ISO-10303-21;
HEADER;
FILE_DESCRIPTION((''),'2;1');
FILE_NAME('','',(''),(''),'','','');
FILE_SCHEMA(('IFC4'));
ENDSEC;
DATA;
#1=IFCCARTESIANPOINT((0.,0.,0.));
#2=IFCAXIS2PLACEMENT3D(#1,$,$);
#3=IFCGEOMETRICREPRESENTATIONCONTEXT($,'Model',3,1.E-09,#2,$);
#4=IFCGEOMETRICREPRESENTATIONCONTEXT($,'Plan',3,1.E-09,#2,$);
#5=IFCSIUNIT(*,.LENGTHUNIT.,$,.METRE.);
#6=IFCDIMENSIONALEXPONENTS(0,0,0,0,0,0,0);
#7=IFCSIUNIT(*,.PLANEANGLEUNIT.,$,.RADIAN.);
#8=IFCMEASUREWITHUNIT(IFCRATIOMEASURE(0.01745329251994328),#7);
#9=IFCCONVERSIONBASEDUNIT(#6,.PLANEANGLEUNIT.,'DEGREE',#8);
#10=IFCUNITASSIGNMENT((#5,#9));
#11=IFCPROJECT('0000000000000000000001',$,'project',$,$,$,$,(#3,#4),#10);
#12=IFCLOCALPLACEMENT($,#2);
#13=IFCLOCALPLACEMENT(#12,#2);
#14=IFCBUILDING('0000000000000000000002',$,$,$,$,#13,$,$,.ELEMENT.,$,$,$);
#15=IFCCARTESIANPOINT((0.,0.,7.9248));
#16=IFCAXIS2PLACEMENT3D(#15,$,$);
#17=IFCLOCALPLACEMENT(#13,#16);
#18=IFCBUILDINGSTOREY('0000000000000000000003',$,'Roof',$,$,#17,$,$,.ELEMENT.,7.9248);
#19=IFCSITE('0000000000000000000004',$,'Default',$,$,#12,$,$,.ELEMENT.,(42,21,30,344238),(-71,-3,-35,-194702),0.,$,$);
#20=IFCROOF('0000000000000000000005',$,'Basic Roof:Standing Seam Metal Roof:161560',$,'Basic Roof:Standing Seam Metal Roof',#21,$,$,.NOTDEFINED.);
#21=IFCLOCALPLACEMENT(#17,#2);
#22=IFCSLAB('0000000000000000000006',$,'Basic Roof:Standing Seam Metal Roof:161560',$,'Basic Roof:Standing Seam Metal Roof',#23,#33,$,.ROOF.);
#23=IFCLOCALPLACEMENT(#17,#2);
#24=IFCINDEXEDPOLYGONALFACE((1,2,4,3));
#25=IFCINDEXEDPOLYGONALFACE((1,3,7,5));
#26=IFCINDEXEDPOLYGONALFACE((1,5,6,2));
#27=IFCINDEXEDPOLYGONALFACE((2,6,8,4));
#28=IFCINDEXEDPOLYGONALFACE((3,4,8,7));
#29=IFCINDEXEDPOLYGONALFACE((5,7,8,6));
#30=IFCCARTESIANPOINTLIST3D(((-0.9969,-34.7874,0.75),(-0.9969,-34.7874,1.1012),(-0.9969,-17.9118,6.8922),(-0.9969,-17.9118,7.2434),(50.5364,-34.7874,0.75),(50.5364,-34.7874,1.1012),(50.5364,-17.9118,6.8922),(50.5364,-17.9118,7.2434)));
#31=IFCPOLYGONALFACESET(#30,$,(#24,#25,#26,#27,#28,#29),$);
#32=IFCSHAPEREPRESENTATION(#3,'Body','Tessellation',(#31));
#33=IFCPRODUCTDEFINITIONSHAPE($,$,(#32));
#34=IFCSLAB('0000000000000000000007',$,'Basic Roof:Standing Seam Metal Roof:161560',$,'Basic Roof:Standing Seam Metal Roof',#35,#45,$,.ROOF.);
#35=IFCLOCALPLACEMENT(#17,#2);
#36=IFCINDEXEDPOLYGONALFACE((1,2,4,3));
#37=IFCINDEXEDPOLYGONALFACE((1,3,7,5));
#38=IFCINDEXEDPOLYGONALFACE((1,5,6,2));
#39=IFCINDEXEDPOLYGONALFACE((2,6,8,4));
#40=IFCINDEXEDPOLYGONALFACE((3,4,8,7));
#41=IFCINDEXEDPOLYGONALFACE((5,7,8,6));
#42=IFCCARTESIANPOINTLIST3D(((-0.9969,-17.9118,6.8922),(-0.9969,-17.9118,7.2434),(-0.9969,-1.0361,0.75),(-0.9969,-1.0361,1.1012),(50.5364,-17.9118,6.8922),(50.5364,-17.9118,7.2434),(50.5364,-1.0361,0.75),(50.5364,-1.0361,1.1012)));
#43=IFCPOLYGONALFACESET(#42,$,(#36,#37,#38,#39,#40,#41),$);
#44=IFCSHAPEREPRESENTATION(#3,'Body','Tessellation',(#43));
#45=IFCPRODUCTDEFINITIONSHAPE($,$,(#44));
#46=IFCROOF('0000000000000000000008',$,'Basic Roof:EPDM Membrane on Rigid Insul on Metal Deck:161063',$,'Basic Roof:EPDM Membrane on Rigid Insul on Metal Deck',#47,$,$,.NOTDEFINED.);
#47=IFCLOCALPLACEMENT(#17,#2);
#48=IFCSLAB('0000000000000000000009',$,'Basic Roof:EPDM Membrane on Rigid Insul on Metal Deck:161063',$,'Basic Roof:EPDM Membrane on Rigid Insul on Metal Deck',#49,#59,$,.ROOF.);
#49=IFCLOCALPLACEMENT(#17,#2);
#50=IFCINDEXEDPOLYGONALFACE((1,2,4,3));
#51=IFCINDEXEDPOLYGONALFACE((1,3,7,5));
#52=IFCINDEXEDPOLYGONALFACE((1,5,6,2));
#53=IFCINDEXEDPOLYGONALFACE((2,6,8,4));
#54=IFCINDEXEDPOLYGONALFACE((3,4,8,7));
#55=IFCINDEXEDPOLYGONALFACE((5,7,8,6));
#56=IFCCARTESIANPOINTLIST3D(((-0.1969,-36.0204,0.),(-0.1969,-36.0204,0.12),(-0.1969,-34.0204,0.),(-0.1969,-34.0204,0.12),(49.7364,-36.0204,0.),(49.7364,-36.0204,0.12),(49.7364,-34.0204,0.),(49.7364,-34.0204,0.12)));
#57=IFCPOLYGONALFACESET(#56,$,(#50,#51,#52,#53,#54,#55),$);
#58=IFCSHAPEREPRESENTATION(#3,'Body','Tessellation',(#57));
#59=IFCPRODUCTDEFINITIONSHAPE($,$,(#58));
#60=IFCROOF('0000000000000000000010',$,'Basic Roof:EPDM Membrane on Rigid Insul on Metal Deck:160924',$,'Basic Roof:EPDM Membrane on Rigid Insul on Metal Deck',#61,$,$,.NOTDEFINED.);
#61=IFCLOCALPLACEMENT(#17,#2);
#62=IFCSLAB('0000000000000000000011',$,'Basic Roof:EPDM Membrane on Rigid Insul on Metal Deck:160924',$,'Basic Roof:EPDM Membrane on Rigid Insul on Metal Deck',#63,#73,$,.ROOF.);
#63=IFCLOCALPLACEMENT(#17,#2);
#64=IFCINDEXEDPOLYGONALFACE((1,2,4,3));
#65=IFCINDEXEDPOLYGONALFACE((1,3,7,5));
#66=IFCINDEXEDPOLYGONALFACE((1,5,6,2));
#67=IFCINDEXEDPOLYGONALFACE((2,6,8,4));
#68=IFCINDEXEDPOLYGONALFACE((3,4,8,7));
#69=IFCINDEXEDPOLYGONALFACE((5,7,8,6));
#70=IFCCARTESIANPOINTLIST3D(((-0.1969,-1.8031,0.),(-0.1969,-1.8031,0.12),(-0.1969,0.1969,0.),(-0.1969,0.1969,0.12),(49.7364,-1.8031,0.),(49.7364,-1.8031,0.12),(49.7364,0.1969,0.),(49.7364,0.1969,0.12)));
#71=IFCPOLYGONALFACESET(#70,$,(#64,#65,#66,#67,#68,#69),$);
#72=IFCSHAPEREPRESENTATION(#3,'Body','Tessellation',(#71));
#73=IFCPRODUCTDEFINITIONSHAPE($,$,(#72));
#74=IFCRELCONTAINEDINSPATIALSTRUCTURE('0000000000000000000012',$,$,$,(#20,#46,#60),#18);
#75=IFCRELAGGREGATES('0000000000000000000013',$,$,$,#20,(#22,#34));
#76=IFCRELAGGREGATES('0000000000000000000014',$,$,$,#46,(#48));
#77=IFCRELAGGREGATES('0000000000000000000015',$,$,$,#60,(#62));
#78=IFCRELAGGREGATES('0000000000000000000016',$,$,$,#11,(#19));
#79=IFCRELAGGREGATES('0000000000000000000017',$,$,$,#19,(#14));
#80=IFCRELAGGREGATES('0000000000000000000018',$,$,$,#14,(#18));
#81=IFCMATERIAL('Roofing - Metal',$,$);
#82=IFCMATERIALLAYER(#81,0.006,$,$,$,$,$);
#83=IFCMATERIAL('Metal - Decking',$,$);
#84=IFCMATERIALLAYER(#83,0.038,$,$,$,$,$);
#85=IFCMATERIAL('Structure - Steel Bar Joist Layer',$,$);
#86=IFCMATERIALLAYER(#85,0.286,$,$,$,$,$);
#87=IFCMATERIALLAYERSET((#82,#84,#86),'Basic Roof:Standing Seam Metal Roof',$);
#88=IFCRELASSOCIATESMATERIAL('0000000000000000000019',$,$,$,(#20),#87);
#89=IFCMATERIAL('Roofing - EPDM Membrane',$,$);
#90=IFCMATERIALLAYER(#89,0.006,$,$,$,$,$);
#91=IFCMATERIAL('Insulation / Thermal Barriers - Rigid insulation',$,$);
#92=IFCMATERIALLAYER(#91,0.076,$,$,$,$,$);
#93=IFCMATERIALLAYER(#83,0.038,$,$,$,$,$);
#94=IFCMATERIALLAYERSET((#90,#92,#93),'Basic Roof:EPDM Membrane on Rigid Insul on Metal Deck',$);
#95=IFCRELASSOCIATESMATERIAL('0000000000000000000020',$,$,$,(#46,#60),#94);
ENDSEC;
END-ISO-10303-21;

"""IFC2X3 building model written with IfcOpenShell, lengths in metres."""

from ifc_helpers import new_model, entity, si_unit, converted_unit, frame, frame_2d, origin, origin_2d_with_axis, place, context, project, spatial, rectangle, extrude, material, layer, layer_set, layer_usage, element, aggregate, save


model = new_model("IFC2X3")

# Units and contexts
model_context = context("Model", 3, precision=1e-09, world=origin())
plan_context = context("Plan", 3, precision=1e-09, world=origin())
ifc_project = project(units=[si_unit("LENGTHUNIT", "METRE"), converted_unit("PLANEANGLEUNIT", "DEGREE", entity("IfcRatioMeasure", 0.01745329251994328), si_unit("PLANEANGLEUNIT", "RADIAN"), dimensions=[0, 0, 0, 0, 0, 0, 0])], contexts=[model_context, plan_context])

# Site, building, storey
site_placement = place(None, origin())
site = spatial("IfcSite", under=ifc_project, at=site_placement, Name="Default", CompositionType="ELEMENT", RefLatitude=(42, 21, 30, 344238), RefLongitude=(-71, -3, -35, -194702), RefElevation=0.0)
building_placement = place(site_placement, origin())
building = spatial("IfcBuilding", under=site, at=building_placement, CompositionType="ELEMENT")
storey_placement = place(building_placement, frame((0.0, 0.0, 7.9248)))
storey = spatial("IfcBuildingStorey", under=building, at=storey_placement, Name="Roof", CompositionType="ELEMENT", Elevation=7.9248)

# Roof, slabs
ifc_material_1 = material(Name="Roofing - Metal")
ifc_layer_1 = layer(ifc_material_1, 0.006)
ifc_material_2 = material(Name="Metal - Decking")
ifc_layer_2 = layer(ifc_material_2, 0.038)
ifc_material_3 = material(Name="Structure - Steel Bar Joist Layer")
ifc_layer_3 = layer(ifc_material_3, 0.286)
ifc_layer_set_1 = layer_set([ifc_layer_1, ifc_layer_2, ifc_layer_3], Name="Basic Roof:Standing Seam Metal Roof")
ifc_layer_usage_1 = layer_usage(ifc_layer_set_1, "AXIS3", "NEGATIVE", 0.0)
roof_1_placement = place(storey_placement, origin())
roof_1 = element("IfcRoof", 1, at=roof_1_placement, inside=storey, material=ifc_layer_usage_1, Name="Basic Roof:Standing Seam Metal Roof:161560", ObjectType="Basic Roof:Standing Seam Metal Roof", ShapeType="NOTDEFINED")
slab_1_placement = place(roof_1_placement, frame((-0.9969, -34.7874, 0.75)))
slab_1 = element("IfcSlab", 2, at=slab_1_placement, Name="Basic Roof:Standing Seam Metal Roof:161560", ObjectType="Basic Roof:Standing Seam Metal Roof", PredefinedType="ROOF", context=model_context, shape_type="SweptSolid", body=[
    extrude(rectangle(XDim=17.9587, YDim=51.5333, at=frame_2d((0.0, 0.0), x_axis=(0.0, 1.0))), frame((25.7667, 8.4378, 3.0711), z_axis=(0.0, -0.34202, 0.939693), x_axis=(1.0, 0.0, 0.0)), (0.0, 0.34202, 0.939693), 0.3512),
])
slab_2_placement = place(roof_1_placement, frame((-0.9969, -34.7874, 0.75)))
slab_2 = element("IfcSlab", 3, at=slab_2_placement, Name="Basic Roof:Standing Seam Metal Roof:161560", ObjectType="Basic Roof:Standing Seam Metal Roof", PredefinedType="ROOF", context=model_context, shape_type="SweptSolid", body=[
    extrude(rectangle(XDim=51.5333, YDim=17.9587, at=origin_2d_with_axis()), frame((25.7667, 25.3135, 3.0711), z_axis=(0.0, 0.34202, 0.939693), x_axis=(1.0, 0.0, 0.0)), (0.0, -0.34202, 0.939693), 0.3512),
])
aggregate(roof_1, [slab_1, slab_2])

# Roofs, slabs
ifc_material_4 = material(Name="Roofing - EPDM Membrane")
ifc_layer_4 = layer(ifc_material_4, 0.006)
ifc_material_5 = material(Name="Insulation / Thermal Barriers - Rigid insulation")
ifc_layer_5 = layer(ifc_material_5, 0.076)
ifc_layer_6 = layer(ifc_material_2, 0.038)
ifc_layer_set_2 = layer_set([ifc_layer_4, ifc_layer_5, ifc_layer_6], Name="Basic Roof:EPDM Membrane on Rigid Insul on Metal Deck")
ifc_layer_usage_2 = layer_usage(ifc_layer_set_2, "AXIS3", "NEGATIVE", 0.0)
roof_2_placement = place(storey_placement, origin())
roof_2 = element("IfcRoof", 4, at=roof_2_placement, inside=storey, material=ifc_layer_usage_2, Name="Basic Roof:EPDM Membrane on Rigid Insul on Metal Deck:161063", ObjectType="Basic Roof:EPDM Membrane on Rigid Insul on Metal Deck", ShapeType="NOTDEFINED")
slab_3_placement = place(roof_2_placement, frame((-0.1969, -36.0204, 0.0)))
slab_3 = element("IfcSlab", 5, at=slab_3_placement, Name="Basic Roof:EPDM Membrane on Rigid Insul on Metal Deck:161063", ObjectType="Basic Roof:EPDM Membrane on Rigid Insul on Metal Deck", PredefinedType="ROOF", context=model_context, shape_type="SweptSolid", body=[
    extrude(rectangle(XDim=49.9333, YDim=2.0, at=origin_2d_with_axis()), frame((24.9667, 1.0, 0.0)), (0.0, 0.0, 1.0), 0.12),
])
aggregate(roof_2, [slab_3])
roof_3_placement = place(storey_placement, origin())
roof_3 = element("IfcRoof", 6, at=roof_3_placement, inside=storey, material=ifc_layer_usage_2, Name="Basic Roof:EPDM Membrane on Rigid Insul on Metal Deck:160924", ObjectType="Basic Roof:EPDM Membrane on Rigid Insul on Metal Deck", ShapeType="NOTDEFINED")
slab_4_placement = place(roof_3_placement, frame((-0.1969, -1.8031, 0.0)))
slab_4 = element("IfcSlab", 7, at=slab_4_placement, Name="Basic Roof:EPDM Membrane on Rigid Insul on Metal Deck:160924", ObjectType="Basic Roof:EPDM Membrane on Rigid Insul on Metal Deck", PredefinedType="ROOF", context=model_context, shape_type="SweptSolid", body=[
    extrude(rectangle(XDim=49.9333, YDim=2.0, at=origin_2d_with_axis()), frame((24.9667, 1.0, 0.0)), (0.0, 0.0, 1.0), 0.12),
])
aggregate(roof_3, [slab_4])

save(model, "model.ifc")
